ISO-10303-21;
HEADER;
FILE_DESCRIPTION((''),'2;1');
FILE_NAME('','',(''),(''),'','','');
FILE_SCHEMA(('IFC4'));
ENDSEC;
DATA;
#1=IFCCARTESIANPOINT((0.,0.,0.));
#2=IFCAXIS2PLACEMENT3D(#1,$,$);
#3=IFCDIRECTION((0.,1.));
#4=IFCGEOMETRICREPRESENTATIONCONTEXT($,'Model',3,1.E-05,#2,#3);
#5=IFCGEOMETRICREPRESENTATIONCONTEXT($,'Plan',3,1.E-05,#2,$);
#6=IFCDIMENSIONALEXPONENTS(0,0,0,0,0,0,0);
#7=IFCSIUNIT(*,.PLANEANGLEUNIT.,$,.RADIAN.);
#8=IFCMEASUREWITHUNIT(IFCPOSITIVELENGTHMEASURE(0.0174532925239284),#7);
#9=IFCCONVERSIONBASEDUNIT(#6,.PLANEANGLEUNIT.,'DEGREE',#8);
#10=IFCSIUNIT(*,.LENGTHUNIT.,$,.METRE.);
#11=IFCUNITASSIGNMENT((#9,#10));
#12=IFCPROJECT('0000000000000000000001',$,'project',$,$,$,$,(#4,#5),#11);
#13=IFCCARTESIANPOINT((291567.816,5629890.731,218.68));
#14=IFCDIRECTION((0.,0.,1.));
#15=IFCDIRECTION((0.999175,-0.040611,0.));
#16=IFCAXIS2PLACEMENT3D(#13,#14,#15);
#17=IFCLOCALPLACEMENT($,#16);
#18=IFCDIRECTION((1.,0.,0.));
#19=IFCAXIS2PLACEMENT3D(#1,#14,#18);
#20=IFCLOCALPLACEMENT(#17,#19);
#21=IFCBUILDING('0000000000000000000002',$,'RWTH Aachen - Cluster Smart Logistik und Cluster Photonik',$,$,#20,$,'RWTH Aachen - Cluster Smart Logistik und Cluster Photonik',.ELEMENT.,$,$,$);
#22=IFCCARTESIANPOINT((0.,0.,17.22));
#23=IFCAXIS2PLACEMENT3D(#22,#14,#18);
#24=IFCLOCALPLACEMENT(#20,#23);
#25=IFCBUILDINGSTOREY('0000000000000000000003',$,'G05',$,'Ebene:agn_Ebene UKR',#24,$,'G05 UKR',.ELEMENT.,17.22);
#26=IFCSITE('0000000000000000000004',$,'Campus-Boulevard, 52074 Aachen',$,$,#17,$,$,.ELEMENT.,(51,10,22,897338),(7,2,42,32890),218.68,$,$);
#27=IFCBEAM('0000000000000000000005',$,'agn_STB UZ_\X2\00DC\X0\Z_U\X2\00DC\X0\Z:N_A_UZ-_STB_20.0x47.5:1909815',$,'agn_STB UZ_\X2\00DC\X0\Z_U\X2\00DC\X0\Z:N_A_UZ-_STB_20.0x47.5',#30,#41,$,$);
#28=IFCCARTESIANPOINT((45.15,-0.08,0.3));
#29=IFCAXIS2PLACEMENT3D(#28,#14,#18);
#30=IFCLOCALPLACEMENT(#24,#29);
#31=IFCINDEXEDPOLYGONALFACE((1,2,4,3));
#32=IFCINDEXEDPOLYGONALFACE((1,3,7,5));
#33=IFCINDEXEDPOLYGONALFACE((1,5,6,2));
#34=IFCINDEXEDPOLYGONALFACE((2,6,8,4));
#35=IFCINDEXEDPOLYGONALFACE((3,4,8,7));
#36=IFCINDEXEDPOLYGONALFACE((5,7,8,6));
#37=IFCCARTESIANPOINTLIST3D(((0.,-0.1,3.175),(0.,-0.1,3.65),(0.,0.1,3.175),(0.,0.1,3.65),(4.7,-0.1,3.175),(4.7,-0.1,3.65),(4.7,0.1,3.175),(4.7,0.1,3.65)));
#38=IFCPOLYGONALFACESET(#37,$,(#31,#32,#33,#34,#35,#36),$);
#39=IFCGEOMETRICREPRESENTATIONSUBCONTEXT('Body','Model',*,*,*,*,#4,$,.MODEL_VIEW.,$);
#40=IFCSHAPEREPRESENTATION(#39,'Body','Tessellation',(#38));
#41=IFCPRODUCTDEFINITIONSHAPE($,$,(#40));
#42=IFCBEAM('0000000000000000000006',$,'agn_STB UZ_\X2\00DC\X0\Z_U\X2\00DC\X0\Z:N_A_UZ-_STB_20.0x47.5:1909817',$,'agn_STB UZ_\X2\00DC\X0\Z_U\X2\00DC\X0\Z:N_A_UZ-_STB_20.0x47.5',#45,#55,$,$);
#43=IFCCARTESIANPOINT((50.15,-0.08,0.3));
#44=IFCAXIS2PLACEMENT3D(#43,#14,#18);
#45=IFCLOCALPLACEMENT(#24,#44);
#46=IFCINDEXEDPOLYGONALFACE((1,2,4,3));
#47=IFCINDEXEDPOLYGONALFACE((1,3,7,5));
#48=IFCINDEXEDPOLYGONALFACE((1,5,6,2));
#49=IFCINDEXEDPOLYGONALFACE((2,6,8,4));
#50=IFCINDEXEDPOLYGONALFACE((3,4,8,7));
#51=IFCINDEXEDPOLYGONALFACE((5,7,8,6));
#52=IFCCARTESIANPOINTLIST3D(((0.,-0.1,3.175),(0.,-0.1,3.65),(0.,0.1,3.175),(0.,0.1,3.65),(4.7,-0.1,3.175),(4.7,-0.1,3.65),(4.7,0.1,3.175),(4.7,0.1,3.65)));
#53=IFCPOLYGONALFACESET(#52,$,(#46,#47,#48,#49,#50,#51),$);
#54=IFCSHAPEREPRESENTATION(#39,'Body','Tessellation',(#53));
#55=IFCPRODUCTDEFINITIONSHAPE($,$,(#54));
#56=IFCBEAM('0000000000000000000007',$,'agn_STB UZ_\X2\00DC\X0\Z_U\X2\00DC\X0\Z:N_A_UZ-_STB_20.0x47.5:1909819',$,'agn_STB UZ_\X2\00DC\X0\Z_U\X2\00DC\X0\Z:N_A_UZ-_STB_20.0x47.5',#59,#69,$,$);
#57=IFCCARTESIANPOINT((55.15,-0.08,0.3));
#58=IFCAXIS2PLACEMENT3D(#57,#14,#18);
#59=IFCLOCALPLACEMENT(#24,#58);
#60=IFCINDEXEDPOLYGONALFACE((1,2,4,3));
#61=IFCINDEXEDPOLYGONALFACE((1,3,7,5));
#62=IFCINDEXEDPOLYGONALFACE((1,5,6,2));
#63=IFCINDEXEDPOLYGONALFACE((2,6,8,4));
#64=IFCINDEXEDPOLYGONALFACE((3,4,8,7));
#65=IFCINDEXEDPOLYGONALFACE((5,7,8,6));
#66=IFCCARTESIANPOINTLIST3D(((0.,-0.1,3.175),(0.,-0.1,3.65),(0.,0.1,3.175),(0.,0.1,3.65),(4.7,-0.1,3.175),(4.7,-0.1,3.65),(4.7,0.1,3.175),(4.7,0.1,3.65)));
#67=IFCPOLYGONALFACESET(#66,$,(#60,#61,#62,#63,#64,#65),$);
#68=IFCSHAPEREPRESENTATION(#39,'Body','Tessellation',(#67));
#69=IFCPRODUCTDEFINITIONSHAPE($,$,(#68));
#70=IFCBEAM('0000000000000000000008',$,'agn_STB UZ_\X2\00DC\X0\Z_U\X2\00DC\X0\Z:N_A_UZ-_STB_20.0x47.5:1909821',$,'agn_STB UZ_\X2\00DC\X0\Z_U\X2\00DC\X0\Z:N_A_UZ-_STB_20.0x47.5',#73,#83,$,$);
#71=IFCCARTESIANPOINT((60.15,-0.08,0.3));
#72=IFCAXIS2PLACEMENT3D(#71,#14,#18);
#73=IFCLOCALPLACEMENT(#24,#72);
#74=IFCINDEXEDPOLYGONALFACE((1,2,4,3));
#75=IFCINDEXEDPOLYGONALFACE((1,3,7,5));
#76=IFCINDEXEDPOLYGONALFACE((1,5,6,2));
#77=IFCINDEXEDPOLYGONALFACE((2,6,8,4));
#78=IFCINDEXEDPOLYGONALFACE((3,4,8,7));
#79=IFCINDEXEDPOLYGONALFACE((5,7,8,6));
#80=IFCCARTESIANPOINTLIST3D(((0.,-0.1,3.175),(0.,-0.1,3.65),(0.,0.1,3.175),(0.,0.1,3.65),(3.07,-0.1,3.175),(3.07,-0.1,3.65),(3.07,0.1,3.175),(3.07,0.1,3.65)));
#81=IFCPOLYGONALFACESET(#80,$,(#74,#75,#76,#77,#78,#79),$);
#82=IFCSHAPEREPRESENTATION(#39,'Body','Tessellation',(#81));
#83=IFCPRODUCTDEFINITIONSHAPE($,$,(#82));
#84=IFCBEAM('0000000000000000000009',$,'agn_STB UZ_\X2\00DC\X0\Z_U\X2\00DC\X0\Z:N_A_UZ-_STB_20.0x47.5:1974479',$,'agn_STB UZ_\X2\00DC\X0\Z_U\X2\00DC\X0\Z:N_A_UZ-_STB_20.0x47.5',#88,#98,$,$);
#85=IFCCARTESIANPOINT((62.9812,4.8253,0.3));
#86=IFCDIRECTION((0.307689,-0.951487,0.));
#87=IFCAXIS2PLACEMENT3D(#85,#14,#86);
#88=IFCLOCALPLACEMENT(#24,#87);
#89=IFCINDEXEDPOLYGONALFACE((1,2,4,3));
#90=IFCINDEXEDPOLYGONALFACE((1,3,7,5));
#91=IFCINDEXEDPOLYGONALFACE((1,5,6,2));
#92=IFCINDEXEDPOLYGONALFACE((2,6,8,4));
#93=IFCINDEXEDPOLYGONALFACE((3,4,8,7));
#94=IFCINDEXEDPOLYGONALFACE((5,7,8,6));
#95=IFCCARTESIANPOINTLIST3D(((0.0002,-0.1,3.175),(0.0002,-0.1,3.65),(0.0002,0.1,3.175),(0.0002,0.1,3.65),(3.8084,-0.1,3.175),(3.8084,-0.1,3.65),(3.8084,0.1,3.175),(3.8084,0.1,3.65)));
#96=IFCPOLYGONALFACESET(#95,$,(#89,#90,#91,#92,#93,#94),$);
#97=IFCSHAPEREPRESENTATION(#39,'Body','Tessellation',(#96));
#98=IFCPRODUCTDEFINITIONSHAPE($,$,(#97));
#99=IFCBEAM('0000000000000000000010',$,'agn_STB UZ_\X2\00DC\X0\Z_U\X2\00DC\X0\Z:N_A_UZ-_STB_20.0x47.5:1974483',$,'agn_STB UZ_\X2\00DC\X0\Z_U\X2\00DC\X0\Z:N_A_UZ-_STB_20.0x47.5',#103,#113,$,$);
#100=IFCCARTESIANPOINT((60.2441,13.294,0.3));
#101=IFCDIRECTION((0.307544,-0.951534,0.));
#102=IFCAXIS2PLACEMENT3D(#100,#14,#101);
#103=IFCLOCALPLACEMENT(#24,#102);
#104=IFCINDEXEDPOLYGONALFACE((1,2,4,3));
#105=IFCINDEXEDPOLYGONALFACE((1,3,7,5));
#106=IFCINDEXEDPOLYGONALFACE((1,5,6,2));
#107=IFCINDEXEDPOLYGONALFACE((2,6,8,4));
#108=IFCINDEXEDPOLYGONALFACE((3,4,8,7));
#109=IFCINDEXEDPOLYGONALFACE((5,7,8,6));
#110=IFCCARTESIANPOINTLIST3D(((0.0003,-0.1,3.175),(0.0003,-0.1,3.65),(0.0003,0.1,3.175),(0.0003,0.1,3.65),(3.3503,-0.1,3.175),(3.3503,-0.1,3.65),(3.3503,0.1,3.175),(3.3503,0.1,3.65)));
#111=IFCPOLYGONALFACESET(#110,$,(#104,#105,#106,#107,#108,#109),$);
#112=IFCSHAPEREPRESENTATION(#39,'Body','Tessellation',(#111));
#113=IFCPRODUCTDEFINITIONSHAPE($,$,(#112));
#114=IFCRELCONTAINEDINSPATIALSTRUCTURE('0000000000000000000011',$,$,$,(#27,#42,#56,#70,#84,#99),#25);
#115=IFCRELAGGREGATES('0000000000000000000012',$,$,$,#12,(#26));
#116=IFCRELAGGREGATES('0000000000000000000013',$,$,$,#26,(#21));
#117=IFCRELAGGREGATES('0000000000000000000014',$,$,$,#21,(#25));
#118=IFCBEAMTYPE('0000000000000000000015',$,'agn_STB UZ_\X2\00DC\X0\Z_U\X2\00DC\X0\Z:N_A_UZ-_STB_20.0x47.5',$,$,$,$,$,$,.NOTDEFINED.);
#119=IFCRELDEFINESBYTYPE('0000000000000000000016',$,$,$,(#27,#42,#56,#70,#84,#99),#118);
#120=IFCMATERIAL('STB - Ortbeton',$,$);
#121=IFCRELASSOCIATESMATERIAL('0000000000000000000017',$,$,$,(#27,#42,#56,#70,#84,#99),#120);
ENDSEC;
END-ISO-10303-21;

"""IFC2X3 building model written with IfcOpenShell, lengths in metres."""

from ifc_helpers import new_model, entity, si_unit, converted_unit, direction, frame, frame_2d, origin, origin_with_axes, place, context, subcontext, project, spatial, rectangle, extrude, material, type_object, element, save


model = new_model("IFC2X3")

# Units and contexts
model_context = context("Model", 3, precision=1e-05, world=origin(), true_north=direction((0.0, 1.0)))
plan_context = context("Plan", 3, precision=1e-05, world=origin())
body_context = subcontext(model_context, "Body", "Model", "MODEL_VIEW")
ifc_project = project(units=[converted_unit("PLANEANGLEUNIT", "DEGREE", entity("IfcPositiveLengthMeasure", 0.0174532925239284), si_unit("PLANEANGLEUNIT", "RADIAN"), dimensions=[0, 0, 0, 0, 0, 0, 0]), si_unit("LENGTHUNIT", "METRE")], contexts=[model_context, plan_context])

# Site, building, storey
site_placement = place(None, frame((291567.816, 5629890.731, 218.68), z_axis=(0.0, 0.0, 1.0), x_axis=(0.999175, -0.040611, 0.0)))
site = spatial("IfcSite", under=ifc_project, at=site_placement, Name="Campus-Boulevard, 52074 Aachen", CompositionType="ELEMENT", RefLatitude=(51, 10, 22, 897338), RefLongitude=(7, 2, 42, 32890), RefElevation=218.68)
building_placement = place(site_placement, origin_with_axes())
building = spatial("IfcBuilding", under=site, at=building_placement, Name="RWTH Aachen - Cluster Smart Logistik und Cluster Photonik", LongName="RWTH Aachen - Cluster Smart Logistik und Cluster Photonik", CompositionType="ELEMENT")
storey_placement = place(building_placement, frame((0.0, 0.0, 17.22), z_axis=(0.0, 0.0, 1.0), x_axis=(1.0, 0.0, 0.0)))
storey = spatial("IfcBuildingStorey", under=building, at=storey_placement, Name="G05", ObjectType="Ebene:agn_Ebene UKR", LongName="G05 UKR", CompositionType="ELEMENT", Elevation=17.22)

# Beams
ifc_material_1 = material(Name="STB - Ortbeton")
beam_type_1 = type_object("IfcBeamType", Name="agn_STB UZ_ÜZ_UÜZ:N_A_UZ-_STB_20.0x47.5", PredefinedType="NOTDEFINED")
for number, where, z_axis, x_axis, name in (
    (1, (45.15, -0.08, 0.3), (0.0, 0.0, 1.0), (1.0, 0.0, 0.0), "agn_STB UZ_ÜZ_UÜZ:N_A_UZ-_STB_20.0x47.5:1909815"),
    (2, (50.15, -0.08, 0.3), (0.0, 0.0, 1.0), (1.0, 0.0, 0.0), "agn_STB UZ_ÜZ_UÜZ:N_A_UZ-_STB_20.0x47.5:1909817"),
    (3, (55.15, -0.08, 0.3), (0.0, 0.0, 1.0), (1.0, 0.0, 0.0), "agn_STB UZ_ÜZ_UÜZ:N_A_UZ-_STB_20.0x47.5:1909819"),
):
    element("IfcBeam", number, at=place(storey_placement, frame(where, z_axis=z_axis, x_axis=x_axis)), inside=storey, type_object=beam_type_1, material=ifc_material_1, Name=name, ObjectType="agn_STB UZ_ÜZ_UÜZ:N_A_UZ-_STB_20.0x47.5", context=body_context, shape_type="SweptSolid", body=[
        extrude(rectangle(XDim=0.475, YDim=0.2, at=frame_2d((0.0, 0.0), x_axis=(1.0, 0.0))), frame((0.0, 0.0, 3.4125), z_axis=(1.0, 0.0, 0.0), x_axis=(0.0, 0.0, -1.0)), (0.0, 0.0, 1.0), 4.7),
    ])
beam_1_placement = place(storey_placement, frame((60.15, -0.08, 0.3), z_axis=(0.0, 0.0, 1.0), x_axis=(1.0, 0.0, 0.0)))
element("IfcBeam", 4, at=beam_1_placement, inside=storey, type_object=beam_type_1, material=ifc_material_1, Name="agn_STB UZ_ÜZ_UÜZ:N_A_UZ-_STB_20.0x47.5:1909821", ObjectType="agn_STB UZ_ÜZ_UÜZ:N_A_UZ-_STB_20.0x47.5", context=body_context, shape_type="SweptSolid", body=[
    extrude(rectangle(XDim=0.475, YDim=0.2, at=frame_2d((0.0, 0.0), x_axis=(1.0, 0.0))), frame((0.0, 0.0, 3.4125), z_axis=(1.0, 0.0, 0.0), x_axis=(0.0, 0.0, -1.0)), (0.0, 0.0, 1.0), 3.07),
])
beam_2_placement = place(storey_placement, frame((62.9812, 4.8253, 0.3), z_axis=(0.0, 0.0, 1.0), x_axis=(0.307689, -0.951487, 0.0)))
element("IfcBeam", 5, at=beam_2_placement, inside=storey, type_object=beam_type_1, material=ifc_material_1, Name="agn_STB UZ_ÜZ_UÜZ:N_A_UZ-_STB_20.0x47.5:1974479", ObjectType="agn_STB UZ_ÜZ_UÜZ:N_A_UZ-_STB_20.0x47.5", context=body_context, shape_type="SweptSolid", body=[
    extrude(rectangle(XDim=0.475, YDim=0.2, at=frame_2d((0.0, 0.0), x_axis=(1.0, 0.0))), frame((0.0002, 0.0, 3.4125), z_axis=(1.0, 0.0, 0.0), x_axis=(0.0, 0.0, -1.0)), (0.0, 0.0, 1.0), 3.8082),
])
beam_3_placement = place(storey_placement, frame((60.2441, 13.294, 0.3), z_axis=(0.0, 0.0, 1.0), x_axis=(0.307544, -0.951534, 0.0)))
element("IfcBeam", 6, at=beam_3_placement, inside=storey, type_object=beam_type_1, material=ifc_material_1, Name="agn_STB UZ_ÜZ_UÜZ:N_A_UZ-_STB_20.0x47.5:1974483", ObjectType="agn_STB UZ_ÜZ_UÜZ:N_A_UZ-_STB_20.0x47.5", context=body_context, shape_type="SweptSolid", body=[
    extrude(rectangle(XDim=0.475, YDim=0.2, at=frame_2d((0.0, 0.0), x_axis=(1.0, 0.0))), frame((0.0003, 0.0, 3.4125), z_axis=(1.0, 0.0, 0.0), x_axis=(0.0, 0.0, -1.0)), (0.0, 0.0, 1.0), 3.35),
])

save(model, "model.ifc")
